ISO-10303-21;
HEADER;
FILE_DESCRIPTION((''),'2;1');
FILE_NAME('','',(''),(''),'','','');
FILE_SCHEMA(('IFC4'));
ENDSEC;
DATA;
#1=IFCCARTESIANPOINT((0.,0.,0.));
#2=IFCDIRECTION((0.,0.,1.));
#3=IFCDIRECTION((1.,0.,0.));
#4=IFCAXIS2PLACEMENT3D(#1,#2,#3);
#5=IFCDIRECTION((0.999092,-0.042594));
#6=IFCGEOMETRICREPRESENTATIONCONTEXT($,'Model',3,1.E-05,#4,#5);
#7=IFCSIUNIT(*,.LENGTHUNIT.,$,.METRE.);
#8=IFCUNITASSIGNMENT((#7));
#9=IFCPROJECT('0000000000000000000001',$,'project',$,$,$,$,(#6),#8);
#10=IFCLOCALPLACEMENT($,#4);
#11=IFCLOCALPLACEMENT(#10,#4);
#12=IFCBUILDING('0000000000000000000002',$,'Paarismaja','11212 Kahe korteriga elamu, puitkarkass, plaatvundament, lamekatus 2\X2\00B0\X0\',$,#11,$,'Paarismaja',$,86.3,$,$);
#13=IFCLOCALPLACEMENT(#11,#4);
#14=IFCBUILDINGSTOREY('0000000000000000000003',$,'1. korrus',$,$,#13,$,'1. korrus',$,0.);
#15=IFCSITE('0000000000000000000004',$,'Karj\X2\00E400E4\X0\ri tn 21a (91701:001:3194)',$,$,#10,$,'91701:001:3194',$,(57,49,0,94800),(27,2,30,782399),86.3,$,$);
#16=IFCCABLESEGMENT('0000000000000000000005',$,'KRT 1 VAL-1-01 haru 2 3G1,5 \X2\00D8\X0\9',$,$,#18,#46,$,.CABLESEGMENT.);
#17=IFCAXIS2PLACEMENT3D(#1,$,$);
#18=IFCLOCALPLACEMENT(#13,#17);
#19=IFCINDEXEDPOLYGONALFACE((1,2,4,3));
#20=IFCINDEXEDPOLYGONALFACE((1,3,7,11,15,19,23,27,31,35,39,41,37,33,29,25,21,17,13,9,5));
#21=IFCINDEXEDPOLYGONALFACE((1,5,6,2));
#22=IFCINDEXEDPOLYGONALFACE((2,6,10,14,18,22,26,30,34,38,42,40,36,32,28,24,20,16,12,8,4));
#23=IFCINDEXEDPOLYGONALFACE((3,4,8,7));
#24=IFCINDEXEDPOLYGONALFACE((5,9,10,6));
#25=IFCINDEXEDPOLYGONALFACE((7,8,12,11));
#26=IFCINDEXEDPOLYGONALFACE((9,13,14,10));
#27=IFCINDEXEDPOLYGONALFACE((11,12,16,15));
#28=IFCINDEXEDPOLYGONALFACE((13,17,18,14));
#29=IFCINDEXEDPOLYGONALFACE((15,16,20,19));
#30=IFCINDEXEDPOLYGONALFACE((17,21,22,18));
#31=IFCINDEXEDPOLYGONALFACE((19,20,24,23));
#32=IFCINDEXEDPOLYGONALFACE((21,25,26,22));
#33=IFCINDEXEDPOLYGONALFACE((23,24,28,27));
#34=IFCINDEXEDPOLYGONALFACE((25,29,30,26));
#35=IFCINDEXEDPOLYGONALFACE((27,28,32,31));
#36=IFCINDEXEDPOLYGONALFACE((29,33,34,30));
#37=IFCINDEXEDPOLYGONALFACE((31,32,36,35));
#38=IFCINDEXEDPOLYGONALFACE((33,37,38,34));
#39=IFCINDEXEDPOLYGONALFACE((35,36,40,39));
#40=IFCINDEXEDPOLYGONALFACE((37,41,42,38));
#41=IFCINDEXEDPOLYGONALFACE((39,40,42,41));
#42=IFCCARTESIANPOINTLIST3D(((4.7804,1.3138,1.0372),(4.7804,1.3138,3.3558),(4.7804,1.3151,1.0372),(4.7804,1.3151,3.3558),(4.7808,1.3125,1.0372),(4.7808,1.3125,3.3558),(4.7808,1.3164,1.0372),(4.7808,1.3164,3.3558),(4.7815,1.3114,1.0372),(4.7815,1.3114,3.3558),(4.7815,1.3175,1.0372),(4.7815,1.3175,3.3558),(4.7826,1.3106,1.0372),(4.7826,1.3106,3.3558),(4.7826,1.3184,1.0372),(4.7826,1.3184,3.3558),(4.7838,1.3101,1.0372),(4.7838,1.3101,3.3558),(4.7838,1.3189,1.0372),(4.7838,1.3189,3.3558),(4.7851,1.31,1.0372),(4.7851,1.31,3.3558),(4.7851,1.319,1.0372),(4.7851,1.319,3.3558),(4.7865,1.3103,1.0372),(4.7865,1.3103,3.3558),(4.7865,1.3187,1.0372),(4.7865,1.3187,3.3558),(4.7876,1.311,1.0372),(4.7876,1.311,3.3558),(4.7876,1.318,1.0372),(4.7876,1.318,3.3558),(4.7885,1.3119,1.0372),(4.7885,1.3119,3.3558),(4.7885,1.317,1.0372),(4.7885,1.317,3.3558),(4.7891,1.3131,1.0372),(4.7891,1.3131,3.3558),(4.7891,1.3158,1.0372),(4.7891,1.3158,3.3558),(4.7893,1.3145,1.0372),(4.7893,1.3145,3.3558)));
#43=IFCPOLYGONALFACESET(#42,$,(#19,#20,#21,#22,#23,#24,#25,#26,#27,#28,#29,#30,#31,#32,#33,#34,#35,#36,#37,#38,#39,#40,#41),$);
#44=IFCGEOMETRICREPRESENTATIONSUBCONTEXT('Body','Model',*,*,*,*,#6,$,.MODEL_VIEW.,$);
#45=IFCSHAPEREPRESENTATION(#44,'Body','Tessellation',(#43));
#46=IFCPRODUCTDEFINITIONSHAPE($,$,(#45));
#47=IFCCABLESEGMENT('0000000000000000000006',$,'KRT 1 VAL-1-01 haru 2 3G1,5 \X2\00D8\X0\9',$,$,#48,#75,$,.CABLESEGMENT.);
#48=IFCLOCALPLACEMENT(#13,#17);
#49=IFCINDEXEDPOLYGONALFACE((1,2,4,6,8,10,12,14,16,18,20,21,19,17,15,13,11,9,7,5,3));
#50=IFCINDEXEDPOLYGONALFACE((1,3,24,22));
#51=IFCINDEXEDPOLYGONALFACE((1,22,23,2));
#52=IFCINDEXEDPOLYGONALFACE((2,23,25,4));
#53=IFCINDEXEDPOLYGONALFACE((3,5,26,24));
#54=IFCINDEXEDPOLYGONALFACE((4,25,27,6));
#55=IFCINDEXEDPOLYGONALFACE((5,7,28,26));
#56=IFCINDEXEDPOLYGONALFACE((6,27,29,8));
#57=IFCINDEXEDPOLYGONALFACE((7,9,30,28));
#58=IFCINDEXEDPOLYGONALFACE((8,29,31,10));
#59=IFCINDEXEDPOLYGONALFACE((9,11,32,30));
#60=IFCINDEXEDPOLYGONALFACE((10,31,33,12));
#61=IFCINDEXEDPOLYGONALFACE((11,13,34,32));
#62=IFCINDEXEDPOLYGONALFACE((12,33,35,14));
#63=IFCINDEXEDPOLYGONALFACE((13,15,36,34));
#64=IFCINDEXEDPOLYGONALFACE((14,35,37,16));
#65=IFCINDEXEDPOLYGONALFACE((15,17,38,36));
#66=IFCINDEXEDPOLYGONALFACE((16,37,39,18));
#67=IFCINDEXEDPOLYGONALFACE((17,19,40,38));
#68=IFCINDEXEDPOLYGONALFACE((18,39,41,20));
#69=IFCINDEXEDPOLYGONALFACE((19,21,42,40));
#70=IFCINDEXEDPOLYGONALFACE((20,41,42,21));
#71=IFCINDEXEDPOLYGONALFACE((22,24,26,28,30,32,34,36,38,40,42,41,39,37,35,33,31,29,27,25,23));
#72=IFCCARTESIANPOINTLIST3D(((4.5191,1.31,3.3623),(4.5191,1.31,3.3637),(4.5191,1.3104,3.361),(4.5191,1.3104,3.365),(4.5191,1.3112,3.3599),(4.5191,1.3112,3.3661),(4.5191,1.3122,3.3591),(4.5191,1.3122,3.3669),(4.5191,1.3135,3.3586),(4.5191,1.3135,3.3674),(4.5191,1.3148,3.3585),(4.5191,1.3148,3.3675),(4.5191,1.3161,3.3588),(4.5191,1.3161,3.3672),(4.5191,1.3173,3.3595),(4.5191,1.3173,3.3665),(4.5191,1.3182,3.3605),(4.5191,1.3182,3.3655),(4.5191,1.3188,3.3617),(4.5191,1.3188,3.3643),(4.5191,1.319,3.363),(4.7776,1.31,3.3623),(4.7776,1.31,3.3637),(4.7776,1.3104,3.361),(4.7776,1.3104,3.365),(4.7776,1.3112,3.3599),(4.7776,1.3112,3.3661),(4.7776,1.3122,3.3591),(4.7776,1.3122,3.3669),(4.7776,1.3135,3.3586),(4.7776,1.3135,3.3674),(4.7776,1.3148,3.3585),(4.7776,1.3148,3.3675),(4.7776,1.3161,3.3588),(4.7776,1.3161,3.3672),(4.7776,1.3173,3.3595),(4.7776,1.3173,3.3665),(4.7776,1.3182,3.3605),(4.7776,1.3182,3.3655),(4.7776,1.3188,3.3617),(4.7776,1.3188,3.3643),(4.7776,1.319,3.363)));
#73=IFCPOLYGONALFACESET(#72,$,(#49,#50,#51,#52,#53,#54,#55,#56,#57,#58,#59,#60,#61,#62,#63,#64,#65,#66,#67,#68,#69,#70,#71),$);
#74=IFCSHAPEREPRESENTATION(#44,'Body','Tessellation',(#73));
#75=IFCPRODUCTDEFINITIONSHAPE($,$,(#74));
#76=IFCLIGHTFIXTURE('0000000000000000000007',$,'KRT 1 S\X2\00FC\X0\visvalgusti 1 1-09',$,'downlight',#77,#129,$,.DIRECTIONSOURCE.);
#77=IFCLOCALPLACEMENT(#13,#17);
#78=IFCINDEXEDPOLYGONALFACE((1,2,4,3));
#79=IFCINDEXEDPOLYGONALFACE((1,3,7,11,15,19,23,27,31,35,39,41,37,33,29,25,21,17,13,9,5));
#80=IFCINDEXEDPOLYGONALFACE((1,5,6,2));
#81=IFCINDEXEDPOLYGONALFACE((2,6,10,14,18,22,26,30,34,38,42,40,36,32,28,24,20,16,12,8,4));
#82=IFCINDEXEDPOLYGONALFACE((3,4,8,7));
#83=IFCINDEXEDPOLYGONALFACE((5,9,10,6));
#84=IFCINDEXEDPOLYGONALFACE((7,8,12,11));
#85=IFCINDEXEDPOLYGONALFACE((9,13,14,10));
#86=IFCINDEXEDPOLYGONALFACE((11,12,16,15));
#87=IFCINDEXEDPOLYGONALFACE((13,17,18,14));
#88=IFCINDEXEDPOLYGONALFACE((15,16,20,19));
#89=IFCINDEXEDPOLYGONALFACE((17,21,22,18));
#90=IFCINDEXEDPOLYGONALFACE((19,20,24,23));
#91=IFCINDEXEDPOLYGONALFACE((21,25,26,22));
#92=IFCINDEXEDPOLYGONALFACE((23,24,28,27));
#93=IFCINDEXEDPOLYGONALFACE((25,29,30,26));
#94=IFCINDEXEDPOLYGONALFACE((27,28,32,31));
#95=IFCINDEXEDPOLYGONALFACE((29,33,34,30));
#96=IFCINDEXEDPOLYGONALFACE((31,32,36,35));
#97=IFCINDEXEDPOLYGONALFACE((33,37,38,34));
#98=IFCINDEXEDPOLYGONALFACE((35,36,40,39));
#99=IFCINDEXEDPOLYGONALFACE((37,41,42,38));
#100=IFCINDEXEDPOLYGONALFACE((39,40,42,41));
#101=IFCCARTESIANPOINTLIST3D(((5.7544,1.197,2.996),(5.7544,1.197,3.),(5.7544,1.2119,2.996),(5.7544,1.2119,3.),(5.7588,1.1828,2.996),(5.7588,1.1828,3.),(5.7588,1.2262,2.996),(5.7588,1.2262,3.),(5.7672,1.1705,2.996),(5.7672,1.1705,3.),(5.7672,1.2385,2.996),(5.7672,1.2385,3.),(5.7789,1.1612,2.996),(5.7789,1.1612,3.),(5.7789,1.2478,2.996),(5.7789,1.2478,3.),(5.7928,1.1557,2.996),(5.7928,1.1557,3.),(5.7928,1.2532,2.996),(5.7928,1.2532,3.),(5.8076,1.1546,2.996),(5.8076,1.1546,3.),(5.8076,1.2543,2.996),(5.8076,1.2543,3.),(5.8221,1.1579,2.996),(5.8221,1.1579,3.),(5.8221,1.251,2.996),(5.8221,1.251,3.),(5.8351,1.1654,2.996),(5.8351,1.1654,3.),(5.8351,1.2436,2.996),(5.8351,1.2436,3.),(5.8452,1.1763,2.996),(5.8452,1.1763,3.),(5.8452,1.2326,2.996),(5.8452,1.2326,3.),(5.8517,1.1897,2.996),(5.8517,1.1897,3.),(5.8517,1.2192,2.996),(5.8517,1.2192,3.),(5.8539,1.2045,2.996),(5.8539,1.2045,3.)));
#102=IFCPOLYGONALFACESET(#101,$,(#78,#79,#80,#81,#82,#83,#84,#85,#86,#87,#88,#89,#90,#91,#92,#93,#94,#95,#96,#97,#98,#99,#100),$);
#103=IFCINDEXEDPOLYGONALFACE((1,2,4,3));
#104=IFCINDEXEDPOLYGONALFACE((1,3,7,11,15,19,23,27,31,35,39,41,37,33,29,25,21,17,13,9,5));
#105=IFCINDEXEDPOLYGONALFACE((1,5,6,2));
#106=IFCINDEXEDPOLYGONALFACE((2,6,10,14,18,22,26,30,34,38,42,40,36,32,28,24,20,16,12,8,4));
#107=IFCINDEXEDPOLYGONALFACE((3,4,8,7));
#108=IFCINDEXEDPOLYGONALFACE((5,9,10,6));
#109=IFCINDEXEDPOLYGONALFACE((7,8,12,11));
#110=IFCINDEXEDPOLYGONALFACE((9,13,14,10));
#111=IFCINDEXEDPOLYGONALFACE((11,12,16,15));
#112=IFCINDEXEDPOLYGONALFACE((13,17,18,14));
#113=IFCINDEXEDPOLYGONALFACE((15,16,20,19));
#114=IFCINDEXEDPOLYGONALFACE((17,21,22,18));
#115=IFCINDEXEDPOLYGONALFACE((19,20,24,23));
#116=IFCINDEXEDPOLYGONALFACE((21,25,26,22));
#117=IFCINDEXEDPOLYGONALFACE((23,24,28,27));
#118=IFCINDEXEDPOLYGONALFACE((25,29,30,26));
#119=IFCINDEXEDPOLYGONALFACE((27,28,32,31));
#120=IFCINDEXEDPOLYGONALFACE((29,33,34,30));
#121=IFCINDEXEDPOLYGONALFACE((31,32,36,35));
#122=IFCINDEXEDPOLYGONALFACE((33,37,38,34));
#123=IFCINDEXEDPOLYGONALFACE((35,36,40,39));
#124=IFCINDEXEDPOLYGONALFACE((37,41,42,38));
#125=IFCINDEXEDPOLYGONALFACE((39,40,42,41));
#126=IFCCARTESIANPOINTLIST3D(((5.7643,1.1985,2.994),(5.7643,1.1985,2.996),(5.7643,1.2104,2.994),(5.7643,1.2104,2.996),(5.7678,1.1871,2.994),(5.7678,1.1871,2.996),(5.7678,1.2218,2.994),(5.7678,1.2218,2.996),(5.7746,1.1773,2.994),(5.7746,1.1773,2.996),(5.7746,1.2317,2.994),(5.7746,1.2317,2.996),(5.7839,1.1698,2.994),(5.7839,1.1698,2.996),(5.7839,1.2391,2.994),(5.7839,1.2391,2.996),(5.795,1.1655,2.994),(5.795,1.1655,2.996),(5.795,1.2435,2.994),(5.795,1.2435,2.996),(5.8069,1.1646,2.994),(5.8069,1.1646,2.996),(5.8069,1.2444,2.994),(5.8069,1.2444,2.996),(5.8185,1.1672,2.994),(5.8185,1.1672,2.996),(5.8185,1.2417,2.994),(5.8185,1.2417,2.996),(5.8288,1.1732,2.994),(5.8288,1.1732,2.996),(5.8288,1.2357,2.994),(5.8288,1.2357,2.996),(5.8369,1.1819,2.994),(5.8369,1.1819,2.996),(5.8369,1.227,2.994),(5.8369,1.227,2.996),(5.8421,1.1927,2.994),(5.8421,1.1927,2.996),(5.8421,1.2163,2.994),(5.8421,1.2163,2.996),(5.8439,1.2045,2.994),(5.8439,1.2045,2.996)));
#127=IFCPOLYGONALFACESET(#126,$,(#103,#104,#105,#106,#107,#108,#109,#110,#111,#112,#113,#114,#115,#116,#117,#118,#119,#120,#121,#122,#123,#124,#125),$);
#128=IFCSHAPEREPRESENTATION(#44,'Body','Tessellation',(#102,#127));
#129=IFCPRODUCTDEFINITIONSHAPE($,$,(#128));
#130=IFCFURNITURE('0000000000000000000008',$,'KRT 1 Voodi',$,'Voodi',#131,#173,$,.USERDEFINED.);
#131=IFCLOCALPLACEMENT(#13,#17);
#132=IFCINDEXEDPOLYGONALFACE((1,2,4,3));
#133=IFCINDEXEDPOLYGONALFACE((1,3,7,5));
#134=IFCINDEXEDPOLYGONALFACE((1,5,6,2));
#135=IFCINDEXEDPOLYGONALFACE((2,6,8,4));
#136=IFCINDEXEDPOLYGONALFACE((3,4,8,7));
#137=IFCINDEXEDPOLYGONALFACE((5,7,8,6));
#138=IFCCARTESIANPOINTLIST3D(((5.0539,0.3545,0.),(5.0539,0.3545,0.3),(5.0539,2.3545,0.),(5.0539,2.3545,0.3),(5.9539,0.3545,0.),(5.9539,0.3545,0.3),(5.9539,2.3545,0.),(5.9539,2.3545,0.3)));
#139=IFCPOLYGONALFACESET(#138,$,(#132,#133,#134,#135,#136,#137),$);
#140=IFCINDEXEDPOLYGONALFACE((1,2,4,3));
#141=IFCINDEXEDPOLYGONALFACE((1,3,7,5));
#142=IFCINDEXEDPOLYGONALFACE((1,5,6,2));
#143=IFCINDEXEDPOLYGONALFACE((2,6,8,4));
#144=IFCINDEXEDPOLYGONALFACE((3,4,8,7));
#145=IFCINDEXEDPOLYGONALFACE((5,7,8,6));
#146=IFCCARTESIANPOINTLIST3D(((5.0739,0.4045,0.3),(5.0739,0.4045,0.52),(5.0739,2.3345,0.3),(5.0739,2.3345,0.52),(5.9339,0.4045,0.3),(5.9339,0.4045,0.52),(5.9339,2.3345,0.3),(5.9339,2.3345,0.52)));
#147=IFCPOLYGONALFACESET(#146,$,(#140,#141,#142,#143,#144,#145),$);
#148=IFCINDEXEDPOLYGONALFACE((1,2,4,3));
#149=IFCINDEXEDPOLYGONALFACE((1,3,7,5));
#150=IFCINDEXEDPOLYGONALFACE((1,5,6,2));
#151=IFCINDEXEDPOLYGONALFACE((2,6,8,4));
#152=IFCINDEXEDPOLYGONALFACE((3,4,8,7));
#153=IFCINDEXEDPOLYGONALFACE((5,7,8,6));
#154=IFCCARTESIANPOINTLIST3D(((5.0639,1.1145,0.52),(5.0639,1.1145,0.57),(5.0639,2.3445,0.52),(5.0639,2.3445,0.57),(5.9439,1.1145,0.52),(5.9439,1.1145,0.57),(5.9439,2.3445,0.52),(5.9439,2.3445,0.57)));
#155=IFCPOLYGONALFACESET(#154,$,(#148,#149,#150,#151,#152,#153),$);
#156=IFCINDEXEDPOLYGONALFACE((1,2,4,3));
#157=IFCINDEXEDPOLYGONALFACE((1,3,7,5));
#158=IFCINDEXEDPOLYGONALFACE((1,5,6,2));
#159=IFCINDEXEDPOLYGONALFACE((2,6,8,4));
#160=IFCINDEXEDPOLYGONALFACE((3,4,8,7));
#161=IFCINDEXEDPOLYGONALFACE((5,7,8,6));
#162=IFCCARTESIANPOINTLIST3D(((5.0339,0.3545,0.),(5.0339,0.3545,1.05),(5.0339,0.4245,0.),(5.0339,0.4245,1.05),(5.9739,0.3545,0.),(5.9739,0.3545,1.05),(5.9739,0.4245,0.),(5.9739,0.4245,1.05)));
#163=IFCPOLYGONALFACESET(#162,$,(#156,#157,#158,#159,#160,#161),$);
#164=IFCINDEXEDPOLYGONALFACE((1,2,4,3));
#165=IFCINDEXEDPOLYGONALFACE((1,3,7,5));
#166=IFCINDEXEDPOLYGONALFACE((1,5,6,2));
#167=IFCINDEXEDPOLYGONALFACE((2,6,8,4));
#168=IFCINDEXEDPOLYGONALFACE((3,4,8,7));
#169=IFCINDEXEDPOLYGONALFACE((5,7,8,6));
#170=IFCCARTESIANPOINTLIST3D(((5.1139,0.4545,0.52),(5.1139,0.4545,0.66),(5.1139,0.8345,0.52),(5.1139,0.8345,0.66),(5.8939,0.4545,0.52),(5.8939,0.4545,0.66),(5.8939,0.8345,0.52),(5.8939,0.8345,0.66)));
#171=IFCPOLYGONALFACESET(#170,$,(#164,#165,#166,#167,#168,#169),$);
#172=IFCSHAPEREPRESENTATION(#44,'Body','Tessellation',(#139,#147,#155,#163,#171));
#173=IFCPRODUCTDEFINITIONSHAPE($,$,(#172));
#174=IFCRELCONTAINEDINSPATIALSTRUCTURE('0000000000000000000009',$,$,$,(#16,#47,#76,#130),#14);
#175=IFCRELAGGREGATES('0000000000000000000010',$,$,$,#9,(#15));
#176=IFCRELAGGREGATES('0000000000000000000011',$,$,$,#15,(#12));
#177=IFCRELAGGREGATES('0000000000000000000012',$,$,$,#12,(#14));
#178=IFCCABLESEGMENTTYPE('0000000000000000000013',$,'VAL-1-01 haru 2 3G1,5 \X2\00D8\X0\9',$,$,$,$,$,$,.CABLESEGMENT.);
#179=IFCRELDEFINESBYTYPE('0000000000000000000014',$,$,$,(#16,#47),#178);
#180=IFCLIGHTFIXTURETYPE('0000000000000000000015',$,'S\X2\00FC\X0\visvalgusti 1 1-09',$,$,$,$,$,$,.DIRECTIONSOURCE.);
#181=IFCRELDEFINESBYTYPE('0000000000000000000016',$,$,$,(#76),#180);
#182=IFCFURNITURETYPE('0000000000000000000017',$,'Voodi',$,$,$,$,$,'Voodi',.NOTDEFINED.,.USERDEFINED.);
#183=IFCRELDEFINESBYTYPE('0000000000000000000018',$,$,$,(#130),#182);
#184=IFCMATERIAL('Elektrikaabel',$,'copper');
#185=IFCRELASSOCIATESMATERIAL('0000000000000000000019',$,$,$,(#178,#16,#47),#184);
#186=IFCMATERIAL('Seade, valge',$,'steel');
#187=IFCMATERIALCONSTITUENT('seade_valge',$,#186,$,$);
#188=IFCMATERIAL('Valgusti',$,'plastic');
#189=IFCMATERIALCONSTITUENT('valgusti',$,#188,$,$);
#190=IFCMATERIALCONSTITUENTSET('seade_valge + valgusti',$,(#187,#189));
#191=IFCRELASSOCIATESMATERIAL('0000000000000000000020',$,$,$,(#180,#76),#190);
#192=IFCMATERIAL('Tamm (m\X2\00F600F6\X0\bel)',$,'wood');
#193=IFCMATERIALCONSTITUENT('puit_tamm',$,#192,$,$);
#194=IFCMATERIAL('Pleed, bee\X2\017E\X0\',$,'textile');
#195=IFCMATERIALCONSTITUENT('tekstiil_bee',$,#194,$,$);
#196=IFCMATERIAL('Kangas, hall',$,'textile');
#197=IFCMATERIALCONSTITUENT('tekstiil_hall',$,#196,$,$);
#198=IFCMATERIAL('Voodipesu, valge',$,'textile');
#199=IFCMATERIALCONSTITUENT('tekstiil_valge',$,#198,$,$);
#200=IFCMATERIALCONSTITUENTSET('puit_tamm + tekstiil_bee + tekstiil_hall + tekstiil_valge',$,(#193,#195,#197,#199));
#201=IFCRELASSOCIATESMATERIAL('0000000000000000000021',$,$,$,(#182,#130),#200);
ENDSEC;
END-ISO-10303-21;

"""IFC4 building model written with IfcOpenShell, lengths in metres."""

from ifc_helpers import new_model, si_unit, direction, frame, origin_with_axes, place, context, subcontext, project, spatial, indexed_curve, circle, outline, extrude, material, constituent, constituent_set, type_object, element, save


model = new_model("IFC4")

# Units and contexts
model_context = context("Model", 3, precision=1e-05, world=origin_with_axes(), true_north=direction((0.999092, -0.042594)))
body_context = subcontext(model_context, "Body", "Model", "MODEL_VIEW")
ifc_project = project(units=[si_unit("LENGTHUNIT", "METRE")], contexts=[model_context])

# Site, building, storey
site_placement = place(None, origin_with_axes())
site = spatial("IfcSite", under=ifc_project, at=site_placement, Name="Karjääri tn 21a (91701:001:3194)", LongName="91701:001:3194", RefLatitude=(57, 49, 0, 94800), RefLongitude=(27, 2, 30, 782399), RefElevation=86.3)
building_placement = place(site_placement, origin_with_axes())
building = spatial("IfcBuilding", under=site, at=building_placement, Name="Paarismaja", Description="11212 Kahe korteriga elamu, puitkarkass, plaatvundament, lamekatus 2°", LongName="Paarismaja", ElevationOfRefHeight=86.3)
storey_placement = place(building_placement, origin_with_axes())
storey = spatial("IfcBuildingStorey", under=building, at=storey_placement, Name="1. korrus", LongName="1. korrus", Elevation=0.0)

# Shared definitions
ifc_material_1 = material(Name="Seade, valge", Category="steel")

# Shared definitions
ifc_material_2 = material(Name="Elektrikaabel", Category="copper")

# Cable segments
cable_segment_type_1 = type_object("IfcCableSegmentType", Name="VAL-1-01 haru 2 3G1,5 Ø9", PredefinedType="CABLESEGMENT", material=ifc_material_2)
cable_segment_1_placement = place(storey_placement, frame((4.7848, 1.3145, 1.0372), z_axis=(0.0, 0.0, 1.0), x_axis=(1.0, 0.0, 0.0)))
element("IfcCableSegment", 1, at=cable_segment_1_placement, inside=storey, type_object=cable_segment_type_1, material=ifc_material_2, Name="KRT 1 VAL-1-01 haru 2 3G1,5 Ø9", PredefinedType="CABLESEGMENT", context=body_context, shape_type="SweptSolid", body=[
    extrude(circle(Radius=0.0045), origin_with_axes(), (0.0, 0.0, 1.0), 2.3186),
])
cable_segment_2_placement = place(storey_placement, frame((4.7776, 1.3145, 3.363), z_axis=(-1.0, 0.0, 0.0), x_axis=(0.0, 1.0, 0.0)))
element("IfcCableSegment", 2, at=cable_segment_2_placement, inside=storey, type_object=cable_segment_type_1, material=ifc_material_2, Name="KRT 1 VAL-1-01 haru 2 3G1,5 Ø9", PredefinedType="CABLESEGMENT", context=body_context, shape_type="SweptSolid", body=[
    extrude(circle(Radius=0.0045), origin_with_axes(), (0.0, 0.0, 1.0), 0.2585),
])

# Light fixture
ifc_constituent_1 = constituent(ifc_material_1, Name="seade_valge")
ifc_material_3 = material(Name="Valgusti", Category="plastic")
ifc_constituent_2 = constituent(ifc_material_3, Name="valgusti")
ifc_constituent_set_1 = constituent_set(constituents=[ifc_constituent_1, ifc_constituent_2], Name="seade_valge + valgusti")
light_fixture_type = type_object("IfcLightFixtureType", Name="Süvisvalgusti 1 1-09", PredefinedType="DIRECTIONSOURCE", material=ifc_constituent_set_1)
light_fixture_placement = place(storey_placement, frame((5.8039, 1.2045, 0.0), z_axis=(0.0, 0.0, 1.0), x_axis=(1.0, 0.0, 0.0)))
element("IfcLightFixture", 3, at=light_fixture_placement, inside=storey, type_object=light_fixture_type, material=ifc_constituent_set_1, Name="KRT 1 Süvisvalgusti 1 1-09", ObjectType="downlight", PredefinedType="DIRECTIONSOURCE", context=body_context, shape_type="SweptSolid", body=[
    extrude(circle(Radius=0.05), frame((0.0, 0.0, 2.996), z_axis=(0.0, 0.0, 1.0), x_axis=(1.0, 0.0, 0.0)), (0.0, 0.0, 1.0), 0.004),
    extrude(circle(Radius=0.04), frame((0.0, 0.0, 2.994), z_axis=(0.0, 0.0, 1.0), x_axis=(1.0, 0.0, 0.0)), (0.0, 0.0, 1.0), 0.002),
])

# Furniture
ifc_material_4 = material(Name="Tamm (mööbel)", Category="wood")
ifc_constituent_3 = constituent(ifc_material_4, Name="puit_tamm")
ifc_material_5 = material(Name="Pleed, beež", Category="textile")
ifc_constituent_4 = constituent(ifc_material_5, Name="tekstiil_bee")
ifc_material_6 = material(Name="Kangas, hall", Category="textile")
ifc_constituent_5 = constituent(ifc_material_6, Name="tekstiil_hall")
ifc_material_7 = material(Name="Voodipesu, valge", Category="textile")
ifc_constituent_6 = constituent(ifc_material_7, Name="tekstiil_valge")
ifc_constituent_set_2 = constituent_set(constituents=[ifc_constituent_3, ifc_constituent_4, ifc_constituent_5, ifc_constituent_6], Name="puit_tamm + tekstiil_bee + tekstiil_hall + tekstiil_valge")
furniture_type = type_object("IfcFurnitureType", Name="Voodi", ElementType="Voodi", AssemblyPlace="NOTDEFINED", PredefinedType="USERDEFINED", material=ifc_constituent_set_2)
furniture_placement = place(storey_placement, frame((5.5039, 0.3545, 0.0), z_axis=(0.0, 0.0, 1.0), x_axis=(1.0, 0.0, 0.0)))
element("IfcFurniture", 4, at=furniture_placement, inside=storey, type_object=furniture_type, material=ifc_constituent_set_2, Name="KRT 1 Voodi", ObjectType="Voodi", PredefinedType="USERDEFINED", context=body_context, shape_type="SweptSolid", body=[
    extrude(outline(indexed_curve([(-0.45, 0.0), (0.45, 0.0), (0.45, 2.0), (-0.45, 2.0), (-0.45, 0.0)], self_intersect=False)), origin_with_axes(), (0.0, 0.0, 1.0), 0.3),
    extrude(outline(indexed_curve([(-0.43, 0.05), (0.43, 0.05), (0.43, 1.98), (-0.43, 1.98), (-0.43, 0.05)], self_intersect=False)), frame((0.0, 0.0, 0.3), z_axis=(0.0, 0.0, 1.0), x_axis=(1.0, 0.0, 0.0)), (0.0, 0.0, 1.0), 0.22),
    extrude(outline(indexed_curve([(-0.44, 0.76), (0.44, 0.76), (0.44, 1.99), (-0.44, 1.99), (-0.44, 0.76)], self_intersect=False)), frame((0.0, 0.0, 0.52), z_axis=(0.0, 0.0, 1.0), x_axis=(1.0, 0.0, 0.0)), (0.0, 0.0, 1.0), 0.05),
    extrude(outline(indexed_curve([(-0.47, 0.0), (0.47, 0.0), (0.47, 0.07), (-0.47, 0.07), (-0.47, 0.0)], self_intersect=False)), origin_with_axes(), (0.0, 0.0, 1.0), 1.05),
    extrude(outline(indexed_curve([(-0.39, 0.1), (0.39, 0.1), (0.39, 0.48), (-0.39, 0.48), (-0.39, 0.1)], self_intersect=False)), frame((0.0, 0.0, 0.52), z_axis=(0.0, 0.0, 1.0), x_axis=(1.0, 0.0, 0.0)), (0.0, 0.0, 1.0), 0.14),
])

save(model, "model.ifc")
